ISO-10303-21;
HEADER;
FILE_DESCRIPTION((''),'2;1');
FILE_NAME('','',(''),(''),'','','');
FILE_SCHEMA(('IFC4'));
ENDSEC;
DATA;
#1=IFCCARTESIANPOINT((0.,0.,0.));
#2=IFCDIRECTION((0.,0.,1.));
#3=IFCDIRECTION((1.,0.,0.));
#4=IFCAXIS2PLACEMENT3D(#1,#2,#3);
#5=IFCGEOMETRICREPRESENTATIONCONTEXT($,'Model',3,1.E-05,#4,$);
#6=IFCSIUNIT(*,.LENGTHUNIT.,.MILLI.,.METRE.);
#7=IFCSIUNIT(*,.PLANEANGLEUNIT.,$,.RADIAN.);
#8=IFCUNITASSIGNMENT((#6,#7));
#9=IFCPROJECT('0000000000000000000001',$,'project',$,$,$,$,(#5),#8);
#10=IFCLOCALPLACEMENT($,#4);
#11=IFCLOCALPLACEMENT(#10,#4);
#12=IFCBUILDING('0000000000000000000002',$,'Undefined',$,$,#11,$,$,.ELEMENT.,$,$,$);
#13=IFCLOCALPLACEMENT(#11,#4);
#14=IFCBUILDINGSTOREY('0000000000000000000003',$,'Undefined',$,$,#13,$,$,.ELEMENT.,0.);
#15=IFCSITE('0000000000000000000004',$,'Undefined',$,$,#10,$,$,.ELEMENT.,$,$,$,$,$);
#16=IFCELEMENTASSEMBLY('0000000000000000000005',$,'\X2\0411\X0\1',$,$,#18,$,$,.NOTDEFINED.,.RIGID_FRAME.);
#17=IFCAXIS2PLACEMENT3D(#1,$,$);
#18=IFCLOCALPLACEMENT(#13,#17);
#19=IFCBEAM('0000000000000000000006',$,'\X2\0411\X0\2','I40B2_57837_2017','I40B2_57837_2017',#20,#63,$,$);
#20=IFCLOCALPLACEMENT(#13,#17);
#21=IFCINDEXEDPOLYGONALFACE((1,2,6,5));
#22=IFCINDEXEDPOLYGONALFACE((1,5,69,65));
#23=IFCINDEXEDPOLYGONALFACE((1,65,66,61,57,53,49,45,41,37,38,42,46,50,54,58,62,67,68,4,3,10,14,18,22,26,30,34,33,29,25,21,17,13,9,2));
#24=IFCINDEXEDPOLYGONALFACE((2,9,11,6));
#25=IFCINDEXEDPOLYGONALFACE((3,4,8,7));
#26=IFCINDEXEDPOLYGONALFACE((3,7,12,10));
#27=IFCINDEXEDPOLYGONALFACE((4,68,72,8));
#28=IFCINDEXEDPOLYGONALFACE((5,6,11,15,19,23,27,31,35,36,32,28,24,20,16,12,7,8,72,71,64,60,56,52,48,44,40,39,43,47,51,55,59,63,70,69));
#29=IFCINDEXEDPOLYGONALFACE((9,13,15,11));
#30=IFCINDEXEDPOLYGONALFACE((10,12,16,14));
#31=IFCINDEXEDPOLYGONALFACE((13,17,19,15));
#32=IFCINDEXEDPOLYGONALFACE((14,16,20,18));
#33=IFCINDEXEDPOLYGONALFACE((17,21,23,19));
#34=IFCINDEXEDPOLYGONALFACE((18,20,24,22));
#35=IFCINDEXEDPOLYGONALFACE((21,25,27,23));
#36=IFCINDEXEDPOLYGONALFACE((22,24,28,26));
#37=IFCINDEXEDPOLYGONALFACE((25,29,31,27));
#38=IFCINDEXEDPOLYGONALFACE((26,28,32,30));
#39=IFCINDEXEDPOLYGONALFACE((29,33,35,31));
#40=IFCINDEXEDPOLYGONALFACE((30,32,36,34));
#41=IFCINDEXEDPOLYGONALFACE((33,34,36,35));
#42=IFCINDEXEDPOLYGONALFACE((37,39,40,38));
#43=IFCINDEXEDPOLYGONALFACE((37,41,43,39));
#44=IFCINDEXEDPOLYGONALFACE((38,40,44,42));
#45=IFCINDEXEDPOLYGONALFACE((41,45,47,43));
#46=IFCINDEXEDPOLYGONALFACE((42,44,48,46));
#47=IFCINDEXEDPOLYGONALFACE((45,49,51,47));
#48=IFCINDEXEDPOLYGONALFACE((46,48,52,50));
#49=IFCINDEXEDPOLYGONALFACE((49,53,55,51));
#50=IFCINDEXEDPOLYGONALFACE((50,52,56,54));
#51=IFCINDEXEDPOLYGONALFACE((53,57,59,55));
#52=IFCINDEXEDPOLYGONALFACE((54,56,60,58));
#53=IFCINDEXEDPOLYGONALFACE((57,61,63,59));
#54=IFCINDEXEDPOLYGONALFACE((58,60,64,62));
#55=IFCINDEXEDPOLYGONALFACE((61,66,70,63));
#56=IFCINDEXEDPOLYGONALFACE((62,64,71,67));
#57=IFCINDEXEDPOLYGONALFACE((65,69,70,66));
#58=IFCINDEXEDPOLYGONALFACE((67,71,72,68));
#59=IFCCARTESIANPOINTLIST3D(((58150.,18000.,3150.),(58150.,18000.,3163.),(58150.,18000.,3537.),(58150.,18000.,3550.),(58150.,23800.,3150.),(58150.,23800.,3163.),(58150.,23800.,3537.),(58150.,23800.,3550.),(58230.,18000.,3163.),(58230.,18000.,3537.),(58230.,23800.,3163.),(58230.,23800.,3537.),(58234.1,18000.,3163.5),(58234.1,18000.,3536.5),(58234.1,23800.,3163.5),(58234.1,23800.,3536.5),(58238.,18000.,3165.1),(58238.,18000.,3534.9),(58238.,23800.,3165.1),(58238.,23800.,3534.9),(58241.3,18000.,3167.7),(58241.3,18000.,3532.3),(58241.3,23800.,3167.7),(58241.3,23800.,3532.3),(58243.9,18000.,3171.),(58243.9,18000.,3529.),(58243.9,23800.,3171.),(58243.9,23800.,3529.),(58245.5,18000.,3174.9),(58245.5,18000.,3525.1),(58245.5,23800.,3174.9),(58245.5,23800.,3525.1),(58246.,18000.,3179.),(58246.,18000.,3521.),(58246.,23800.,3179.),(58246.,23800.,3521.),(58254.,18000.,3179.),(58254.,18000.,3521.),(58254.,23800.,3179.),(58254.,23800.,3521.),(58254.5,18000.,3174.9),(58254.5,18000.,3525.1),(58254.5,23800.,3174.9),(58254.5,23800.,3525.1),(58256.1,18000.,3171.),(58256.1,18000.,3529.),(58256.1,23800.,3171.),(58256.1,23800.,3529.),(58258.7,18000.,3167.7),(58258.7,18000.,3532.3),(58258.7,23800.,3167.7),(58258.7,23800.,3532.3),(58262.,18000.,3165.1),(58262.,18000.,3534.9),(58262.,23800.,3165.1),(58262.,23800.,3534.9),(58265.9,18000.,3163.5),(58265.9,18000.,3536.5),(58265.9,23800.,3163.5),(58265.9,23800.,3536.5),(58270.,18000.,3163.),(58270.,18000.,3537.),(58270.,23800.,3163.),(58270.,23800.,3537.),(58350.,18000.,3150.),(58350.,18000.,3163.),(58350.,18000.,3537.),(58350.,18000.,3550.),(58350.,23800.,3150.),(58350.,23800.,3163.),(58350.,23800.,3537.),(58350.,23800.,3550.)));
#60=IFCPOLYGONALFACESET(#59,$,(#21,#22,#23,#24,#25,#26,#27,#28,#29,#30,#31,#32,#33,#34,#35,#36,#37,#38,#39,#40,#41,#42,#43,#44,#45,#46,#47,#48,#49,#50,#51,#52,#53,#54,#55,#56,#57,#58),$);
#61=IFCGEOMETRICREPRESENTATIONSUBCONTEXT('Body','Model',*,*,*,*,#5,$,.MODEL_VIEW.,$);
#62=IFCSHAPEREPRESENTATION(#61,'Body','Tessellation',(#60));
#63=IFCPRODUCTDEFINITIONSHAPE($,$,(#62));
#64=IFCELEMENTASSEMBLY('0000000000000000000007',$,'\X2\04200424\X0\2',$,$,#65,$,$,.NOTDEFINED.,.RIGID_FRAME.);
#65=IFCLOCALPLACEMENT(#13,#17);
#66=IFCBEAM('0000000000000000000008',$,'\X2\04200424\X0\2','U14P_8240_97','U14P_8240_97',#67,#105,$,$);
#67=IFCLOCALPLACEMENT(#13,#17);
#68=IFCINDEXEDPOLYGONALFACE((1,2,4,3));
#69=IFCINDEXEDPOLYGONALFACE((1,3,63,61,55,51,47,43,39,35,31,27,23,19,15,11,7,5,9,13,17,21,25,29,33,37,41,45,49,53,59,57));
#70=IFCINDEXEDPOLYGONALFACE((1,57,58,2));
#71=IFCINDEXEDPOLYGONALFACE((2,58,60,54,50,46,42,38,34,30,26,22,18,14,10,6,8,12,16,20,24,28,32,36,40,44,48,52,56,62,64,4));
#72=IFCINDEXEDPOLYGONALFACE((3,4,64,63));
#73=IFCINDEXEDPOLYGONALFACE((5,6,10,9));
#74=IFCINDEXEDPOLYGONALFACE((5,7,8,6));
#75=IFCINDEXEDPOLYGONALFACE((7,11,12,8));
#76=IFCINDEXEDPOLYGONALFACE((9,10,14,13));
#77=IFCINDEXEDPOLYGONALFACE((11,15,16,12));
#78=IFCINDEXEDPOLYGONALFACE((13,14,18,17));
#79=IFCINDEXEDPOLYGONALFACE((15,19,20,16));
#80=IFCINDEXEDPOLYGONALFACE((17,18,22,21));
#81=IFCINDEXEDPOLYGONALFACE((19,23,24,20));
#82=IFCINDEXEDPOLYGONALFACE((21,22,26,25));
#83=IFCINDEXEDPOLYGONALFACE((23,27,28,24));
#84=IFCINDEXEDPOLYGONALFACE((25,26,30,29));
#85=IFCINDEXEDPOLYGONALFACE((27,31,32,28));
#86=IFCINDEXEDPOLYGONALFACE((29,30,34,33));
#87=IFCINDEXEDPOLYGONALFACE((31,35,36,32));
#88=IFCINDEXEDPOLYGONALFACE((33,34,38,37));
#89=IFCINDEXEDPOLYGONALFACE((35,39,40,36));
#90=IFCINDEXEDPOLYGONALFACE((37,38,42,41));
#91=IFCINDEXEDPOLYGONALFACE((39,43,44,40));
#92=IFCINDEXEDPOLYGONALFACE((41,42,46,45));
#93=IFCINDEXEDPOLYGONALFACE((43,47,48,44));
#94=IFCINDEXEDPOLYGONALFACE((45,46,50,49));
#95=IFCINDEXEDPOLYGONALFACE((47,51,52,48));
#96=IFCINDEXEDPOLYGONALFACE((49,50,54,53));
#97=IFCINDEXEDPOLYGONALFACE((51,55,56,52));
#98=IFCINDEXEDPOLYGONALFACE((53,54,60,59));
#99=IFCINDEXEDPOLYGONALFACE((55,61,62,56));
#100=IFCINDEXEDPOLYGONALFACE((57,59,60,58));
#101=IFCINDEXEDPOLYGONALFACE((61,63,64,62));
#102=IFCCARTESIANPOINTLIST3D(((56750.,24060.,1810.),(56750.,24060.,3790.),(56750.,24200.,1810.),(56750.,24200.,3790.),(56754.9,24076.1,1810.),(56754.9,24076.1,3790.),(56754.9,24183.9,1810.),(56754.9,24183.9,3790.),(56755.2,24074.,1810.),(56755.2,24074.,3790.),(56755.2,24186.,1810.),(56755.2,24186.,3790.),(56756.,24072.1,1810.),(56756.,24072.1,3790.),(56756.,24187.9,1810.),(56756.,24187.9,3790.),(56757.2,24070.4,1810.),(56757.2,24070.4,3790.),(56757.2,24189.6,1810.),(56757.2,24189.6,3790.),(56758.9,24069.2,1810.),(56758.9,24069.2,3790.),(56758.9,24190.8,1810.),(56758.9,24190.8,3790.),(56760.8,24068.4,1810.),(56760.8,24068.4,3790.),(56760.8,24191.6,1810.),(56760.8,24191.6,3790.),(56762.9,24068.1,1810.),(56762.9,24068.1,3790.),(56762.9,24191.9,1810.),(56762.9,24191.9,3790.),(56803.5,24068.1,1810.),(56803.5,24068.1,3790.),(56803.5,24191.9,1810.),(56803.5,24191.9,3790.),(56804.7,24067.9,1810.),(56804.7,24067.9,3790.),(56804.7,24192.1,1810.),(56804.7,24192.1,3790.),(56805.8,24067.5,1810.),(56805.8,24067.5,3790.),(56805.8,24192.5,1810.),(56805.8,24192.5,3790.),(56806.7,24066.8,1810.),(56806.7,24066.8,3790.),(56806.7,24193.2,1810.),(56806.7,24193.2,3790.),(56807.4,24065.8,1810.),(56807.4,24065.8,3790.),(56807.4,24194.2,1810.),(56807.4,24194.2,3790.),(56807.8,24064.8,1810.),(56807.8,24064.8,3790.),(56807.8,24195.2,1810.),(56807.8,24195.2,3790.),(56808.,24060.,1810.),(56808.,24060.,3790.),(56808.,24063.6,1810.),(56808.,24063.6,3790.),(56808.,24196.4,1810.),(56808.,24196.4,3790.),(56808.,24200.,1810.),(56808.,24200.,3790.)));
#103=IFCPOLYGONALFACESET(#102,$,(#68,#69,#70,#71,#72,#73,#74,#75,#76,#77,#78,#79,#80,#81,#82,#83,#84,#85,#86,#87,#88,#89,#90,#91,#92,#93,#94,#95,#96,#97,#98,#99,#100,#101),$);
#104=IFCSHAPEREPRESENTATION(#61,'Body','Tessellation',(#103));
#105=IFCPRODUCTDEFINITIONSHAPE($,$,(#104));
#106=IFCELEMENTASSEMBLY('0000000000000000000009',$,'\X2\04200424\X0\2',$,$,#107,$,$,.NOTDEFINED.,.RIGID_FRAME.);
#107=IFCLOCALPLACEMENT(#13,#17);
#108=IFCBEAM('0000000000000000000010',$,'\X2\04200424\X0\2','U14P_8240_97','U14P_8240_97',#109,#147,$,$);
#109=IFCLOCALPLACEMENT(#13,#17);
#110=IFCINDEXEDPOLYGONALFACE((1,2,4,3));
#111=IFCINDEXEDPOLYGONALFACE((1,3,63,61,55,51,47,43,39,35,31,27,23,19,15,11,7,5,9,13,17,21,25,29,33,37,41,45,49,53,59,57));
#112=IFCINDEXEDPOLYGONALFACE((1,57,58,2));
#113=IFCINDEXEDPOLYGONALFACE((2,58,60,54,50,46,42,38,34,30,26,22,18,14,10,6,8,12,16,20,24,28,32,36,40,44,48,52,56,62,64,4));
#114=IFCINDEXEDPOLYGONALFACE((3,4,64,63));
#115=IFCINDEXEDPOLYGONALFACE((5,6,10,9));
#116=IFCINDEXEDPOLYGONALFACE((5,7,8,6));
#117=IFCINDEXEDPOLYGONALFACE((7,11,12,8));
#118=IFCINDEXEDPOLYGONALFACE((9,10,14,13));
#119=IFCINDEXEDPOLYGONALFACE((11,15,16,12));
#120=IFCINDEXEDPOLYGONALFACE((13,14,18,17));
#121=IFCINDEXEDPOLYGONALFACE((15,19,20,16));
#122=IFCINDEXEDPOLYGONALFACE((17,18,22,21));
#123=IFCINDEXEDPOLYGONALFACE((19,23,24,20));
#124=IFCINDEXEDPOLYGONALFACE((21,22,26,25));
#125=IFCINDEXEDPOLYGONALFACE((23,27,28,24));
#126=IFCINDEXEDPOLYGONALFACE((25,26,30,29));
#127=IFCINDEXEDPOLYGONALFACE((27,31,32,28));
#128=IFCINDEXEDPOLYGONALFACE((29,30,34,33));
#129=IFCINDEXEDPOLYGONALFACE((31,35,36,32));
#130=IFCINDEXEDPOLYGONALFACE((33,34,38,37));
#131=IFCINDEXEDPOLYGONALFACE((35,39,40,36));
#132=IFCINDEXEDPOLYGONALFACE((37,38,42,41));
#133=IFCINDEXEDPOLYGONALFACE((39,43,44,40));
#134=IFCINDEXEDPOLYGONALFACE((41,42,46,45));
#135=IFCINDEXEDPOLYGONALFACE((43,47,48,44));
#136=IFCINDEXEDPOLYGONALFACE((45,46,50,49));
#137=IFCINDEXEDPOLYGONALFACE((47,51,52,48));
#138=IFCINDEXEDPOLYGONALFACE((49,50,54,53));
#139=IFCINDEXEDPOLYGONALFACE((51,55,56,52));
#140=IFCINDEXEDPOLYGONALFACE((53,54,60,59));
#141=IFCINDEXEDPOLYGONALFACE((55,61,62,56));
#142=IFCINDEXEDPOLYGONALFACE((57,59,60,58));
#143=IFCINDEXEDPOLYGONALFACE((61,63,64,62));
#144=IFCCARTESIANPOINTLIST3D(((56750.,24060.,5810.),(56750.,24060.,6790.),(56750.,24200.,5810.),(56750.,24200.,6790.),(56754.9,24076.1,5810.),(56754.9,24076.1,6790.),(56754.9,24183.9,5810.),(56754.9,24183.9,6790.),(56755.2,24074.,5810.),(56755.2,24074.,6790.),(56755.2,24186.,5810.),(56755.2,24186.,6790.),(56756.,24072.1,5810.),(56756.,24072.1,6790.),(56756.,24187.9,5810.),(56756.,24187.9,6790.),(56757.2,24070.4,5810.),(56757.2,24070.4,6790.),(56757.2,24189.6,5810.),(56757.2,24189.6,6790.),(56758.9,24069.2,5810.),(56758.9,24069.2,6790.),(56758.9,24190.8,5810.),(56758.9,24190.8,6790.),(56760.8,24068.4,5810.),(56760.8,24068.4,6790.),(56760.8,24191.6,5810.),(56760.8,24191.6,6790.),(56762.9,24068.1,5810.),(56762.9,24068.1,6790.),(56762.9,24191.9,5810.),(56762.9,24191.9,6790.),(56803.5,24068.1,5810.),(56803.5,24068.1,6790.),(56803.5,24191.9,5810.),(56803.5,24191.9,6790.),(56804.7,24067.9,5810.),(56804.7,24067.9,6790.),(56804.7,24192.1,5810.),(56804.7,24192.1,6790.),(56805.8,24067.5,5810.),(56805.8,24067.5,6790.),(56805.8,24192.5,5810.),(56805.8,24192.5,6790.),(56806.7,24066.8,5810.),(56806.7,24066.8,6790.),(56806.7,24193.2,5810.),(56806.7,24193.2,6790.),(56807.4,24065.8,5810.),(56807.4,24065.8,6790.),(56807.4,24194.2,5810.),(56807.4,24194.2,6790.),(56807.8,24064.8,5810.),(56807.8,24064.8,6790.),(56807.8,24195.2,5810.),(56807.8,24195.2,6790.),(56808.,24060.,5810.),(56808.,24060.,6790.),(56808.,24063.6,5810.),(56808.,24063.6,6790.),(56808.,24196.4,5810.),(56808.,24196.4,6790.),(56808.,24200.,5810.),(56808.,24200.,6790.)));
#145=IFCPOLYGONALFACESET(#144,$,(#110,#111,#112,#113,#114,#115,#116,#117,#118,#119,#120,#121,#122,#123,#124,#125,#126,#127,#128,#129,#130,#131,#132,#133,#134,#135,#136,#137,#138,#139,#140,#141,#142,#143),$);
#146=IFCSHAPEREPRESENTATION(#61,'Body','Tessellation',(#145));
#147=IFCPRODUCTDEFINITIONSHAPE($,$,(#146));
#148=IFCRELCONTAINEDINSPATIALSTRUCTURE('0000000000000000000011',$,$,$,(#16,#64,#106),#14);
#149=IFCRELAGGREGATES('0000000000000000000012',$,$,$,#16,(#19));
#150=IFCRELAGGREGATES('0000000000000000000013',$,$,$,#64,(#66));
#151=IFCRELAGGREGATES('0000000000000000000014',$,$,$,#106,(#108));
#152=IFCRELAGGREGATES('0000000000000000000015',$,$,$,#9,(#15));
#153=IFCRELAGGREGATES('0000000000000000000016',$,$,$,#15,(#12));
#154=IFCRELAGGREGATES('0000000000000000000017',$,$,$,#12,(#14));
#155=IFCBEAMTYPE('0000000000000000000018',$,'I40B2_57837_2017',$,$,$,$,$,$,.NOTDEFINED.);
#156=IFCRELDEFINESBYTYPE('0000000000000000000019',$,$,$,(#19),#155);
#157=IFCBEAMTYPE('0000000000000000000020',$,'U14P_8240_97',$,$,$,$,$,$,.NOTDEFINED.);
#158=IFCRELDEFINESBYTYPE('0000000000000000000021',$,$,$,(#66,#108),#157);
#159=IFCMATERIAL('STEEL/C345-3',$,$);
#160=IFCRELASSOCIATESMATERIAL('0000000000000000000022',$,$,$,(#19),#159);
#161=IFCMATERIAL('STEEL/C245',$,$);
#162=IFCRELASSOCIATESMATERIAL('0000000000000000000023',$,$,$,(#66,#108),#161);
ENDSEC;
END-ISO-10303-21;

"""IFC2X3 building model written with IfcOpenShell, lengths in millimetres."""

from ifc_helpers import new_model, si_unit, frame, origin_with_axes, origin_2d_with_axis, place, context, subcontext, project, spatial, i_section, u_section, extrude, material, type_object, element, aggregate, save


model = new_model("IFC2X3")

# Units and contexts
model_context = context("Model", 3, precision=1e-05, world=origin_with_axes())
body_context = subcontext(model_context, "Body", "Model", "MODEL_VIEW")
ifc_project = project(units=[si_unit("LENGTHUNIT", "METRE", prefix="MILLI"), si_unit("PLANEANGLEUNIT", "RADIAN")], contexts=[model_context])

# Site, building, storey
site_placement = place(None, origin_with_axes())
site = spatial("IfcSite", under=ifc_project, at=site_placement, Name="Undefined", CompositionType="ELEMENT")
building_placement = place(site_placement, origin_with_axes())
building = spatial("IfcBuilding", under=site, at=building_placement, Name="Undefined", CompositionType="ELEMENT")
storey_placement = place(building_placement, origin_with_axes())
storey = spatial("IfcBuildingStorey", under=building, at=storey_placement, Name="Undefined", CompositionType="ELEMENT", Elevation=0.0)

# Shared definitions
ifc_material_1 = material(Name="STEEL/C345-3")

# Element assemblies, beams
ifc_material_2 = material(Name="STEEL/C245")
assembly_1_placement = place(storey_placement, origin_with_axes())
assembly_1 = element("IfcElementAssembly", 1, at=assembly_1_placement, inside=storey, Name="Б1", AssemblyPlace="NOTDEFINED", PredefinedType="RIGID_FRAME")
beam_type_1 = type_object("IfcBeamType", Name="I40B2_57837_2017", PredefinedType="NOTDEFINED")
beam_1_placement = place(assembly_1_placement, frame((58250.0, 23800.0, 3350.0), z_axis=(0.0, 0.0, -1.0), x_axis=(0.0, -1.0, 0.0)))
beam_1 = element("IfcBeam", 2, at=beam_1_placement, type_object=beam_type_1, material=ifc_material_1, Name="Б2", Description="I40B2_57837_2017", ObjectType="I40B2_57837_2017", context=body_context, shape_type="SweptSolid", body=[
    extrude(i_section(OverallWidth=200.0, OverallDepth=400.0, WebThickness=8.0, FlangeThickness=13.0, FilletRadius=16.0, at=origin_2d_with_axis()), frame((5800.0, 0.0, 0.0), z_axis=(-1.0, 0.0, 0.0), x_axis=(0.0, -1.0, 0.0)), (0.0, 0.0, 1.0), 5800.0),
])
aggregate(assembly_1, [beam_1])
assembly_2_placement = place(storey_placement, origin_with_axes())
assembly_2 = element("IfcElementAssembly", 3, at=assembly_2_placement, inside=storey, Name="РФ2", AssemblyPlace="NOTDEFINED", PredefinedType="RIGID_FRAME")
beam_type_2 = type_object("IfcBeamType", Name="U14P_8240_97", PredefinedType="NOTDEFINED")
beam_2_placement = place(assembly_2_placement, frame((56779.0, 24130.0, 3790.0), z_axis=(0.0, 1.0, 0.0), x_axis=(0.0, 0.0, -1.0)))
beam_2 = element("IfcBeam", 4, at=beam_2_placement, type_object=beam_type_2, material=ifc_material_2, Name="РФ2", Description="U14P_8240_97", ObjectType="U14P_8240_97", context=body_context, shape_type="SweptSolid", body=[
    extrude(u_section(Depth=140.0, FlangeWidth=58.0, WebThickness=4.9, FlangeThickness=8.1, FilletRadius=8.0, EdgeRadius=4.5, at=origin_2d_with_axis()), frame((1980.0, 0.0, 0.0), z_axis=(-1.0, 0.0, 0.0), x_axis=(0.0, -1.0, 0.0)), (0.0, 0.0, 1.0), 1980.0),
])
aggregate(assembly_2, [beam_2])
assembly_3_placement = place(storey_placement, origin_with_axes())
assembly_3 = element("IfcElementAssembly", 5, at=assembly_3_placement, inside=storey, Name="РФ2", AssemblyPlace="NOTDEFINED", PredefinedType="RIGID_FRAME")
beam_3_placement = place(assembly_3_placement, frame((56779.0, 24130.0, 6790.0), z_axis=(0.0, 1.0, 0.0), x_axis=(0.0, 0.0, -1.0)))
beam_3 = element("IfcBeam", 6, at=beam_3_placement, type_object=beam_type_2, material=ifc_material_2, Name="РФ2", Description="U14P_8240_97", ObjectType="U14P_8240_97", context=body_context, shape_type="SweptSolid", body=[
    extrude(u_section(Depth=140.0, FlangeWidth=58.0, WebThickness=4.9, FlangeThickness=8.1, FilletRadius=8.0, EdgeRadius=4.5, at=origin_2d_with_axis()), frame((980.0, 0.0, 0.0), z_axis=(-1.0, 0.0, 0.0), x_axis=(0.0, -1.0, 0.0)), (0.0, 0.0, 1.0), 980.0),
])
aggregate(assembly_3, [beam_3])

save(model, "model.ifc")
